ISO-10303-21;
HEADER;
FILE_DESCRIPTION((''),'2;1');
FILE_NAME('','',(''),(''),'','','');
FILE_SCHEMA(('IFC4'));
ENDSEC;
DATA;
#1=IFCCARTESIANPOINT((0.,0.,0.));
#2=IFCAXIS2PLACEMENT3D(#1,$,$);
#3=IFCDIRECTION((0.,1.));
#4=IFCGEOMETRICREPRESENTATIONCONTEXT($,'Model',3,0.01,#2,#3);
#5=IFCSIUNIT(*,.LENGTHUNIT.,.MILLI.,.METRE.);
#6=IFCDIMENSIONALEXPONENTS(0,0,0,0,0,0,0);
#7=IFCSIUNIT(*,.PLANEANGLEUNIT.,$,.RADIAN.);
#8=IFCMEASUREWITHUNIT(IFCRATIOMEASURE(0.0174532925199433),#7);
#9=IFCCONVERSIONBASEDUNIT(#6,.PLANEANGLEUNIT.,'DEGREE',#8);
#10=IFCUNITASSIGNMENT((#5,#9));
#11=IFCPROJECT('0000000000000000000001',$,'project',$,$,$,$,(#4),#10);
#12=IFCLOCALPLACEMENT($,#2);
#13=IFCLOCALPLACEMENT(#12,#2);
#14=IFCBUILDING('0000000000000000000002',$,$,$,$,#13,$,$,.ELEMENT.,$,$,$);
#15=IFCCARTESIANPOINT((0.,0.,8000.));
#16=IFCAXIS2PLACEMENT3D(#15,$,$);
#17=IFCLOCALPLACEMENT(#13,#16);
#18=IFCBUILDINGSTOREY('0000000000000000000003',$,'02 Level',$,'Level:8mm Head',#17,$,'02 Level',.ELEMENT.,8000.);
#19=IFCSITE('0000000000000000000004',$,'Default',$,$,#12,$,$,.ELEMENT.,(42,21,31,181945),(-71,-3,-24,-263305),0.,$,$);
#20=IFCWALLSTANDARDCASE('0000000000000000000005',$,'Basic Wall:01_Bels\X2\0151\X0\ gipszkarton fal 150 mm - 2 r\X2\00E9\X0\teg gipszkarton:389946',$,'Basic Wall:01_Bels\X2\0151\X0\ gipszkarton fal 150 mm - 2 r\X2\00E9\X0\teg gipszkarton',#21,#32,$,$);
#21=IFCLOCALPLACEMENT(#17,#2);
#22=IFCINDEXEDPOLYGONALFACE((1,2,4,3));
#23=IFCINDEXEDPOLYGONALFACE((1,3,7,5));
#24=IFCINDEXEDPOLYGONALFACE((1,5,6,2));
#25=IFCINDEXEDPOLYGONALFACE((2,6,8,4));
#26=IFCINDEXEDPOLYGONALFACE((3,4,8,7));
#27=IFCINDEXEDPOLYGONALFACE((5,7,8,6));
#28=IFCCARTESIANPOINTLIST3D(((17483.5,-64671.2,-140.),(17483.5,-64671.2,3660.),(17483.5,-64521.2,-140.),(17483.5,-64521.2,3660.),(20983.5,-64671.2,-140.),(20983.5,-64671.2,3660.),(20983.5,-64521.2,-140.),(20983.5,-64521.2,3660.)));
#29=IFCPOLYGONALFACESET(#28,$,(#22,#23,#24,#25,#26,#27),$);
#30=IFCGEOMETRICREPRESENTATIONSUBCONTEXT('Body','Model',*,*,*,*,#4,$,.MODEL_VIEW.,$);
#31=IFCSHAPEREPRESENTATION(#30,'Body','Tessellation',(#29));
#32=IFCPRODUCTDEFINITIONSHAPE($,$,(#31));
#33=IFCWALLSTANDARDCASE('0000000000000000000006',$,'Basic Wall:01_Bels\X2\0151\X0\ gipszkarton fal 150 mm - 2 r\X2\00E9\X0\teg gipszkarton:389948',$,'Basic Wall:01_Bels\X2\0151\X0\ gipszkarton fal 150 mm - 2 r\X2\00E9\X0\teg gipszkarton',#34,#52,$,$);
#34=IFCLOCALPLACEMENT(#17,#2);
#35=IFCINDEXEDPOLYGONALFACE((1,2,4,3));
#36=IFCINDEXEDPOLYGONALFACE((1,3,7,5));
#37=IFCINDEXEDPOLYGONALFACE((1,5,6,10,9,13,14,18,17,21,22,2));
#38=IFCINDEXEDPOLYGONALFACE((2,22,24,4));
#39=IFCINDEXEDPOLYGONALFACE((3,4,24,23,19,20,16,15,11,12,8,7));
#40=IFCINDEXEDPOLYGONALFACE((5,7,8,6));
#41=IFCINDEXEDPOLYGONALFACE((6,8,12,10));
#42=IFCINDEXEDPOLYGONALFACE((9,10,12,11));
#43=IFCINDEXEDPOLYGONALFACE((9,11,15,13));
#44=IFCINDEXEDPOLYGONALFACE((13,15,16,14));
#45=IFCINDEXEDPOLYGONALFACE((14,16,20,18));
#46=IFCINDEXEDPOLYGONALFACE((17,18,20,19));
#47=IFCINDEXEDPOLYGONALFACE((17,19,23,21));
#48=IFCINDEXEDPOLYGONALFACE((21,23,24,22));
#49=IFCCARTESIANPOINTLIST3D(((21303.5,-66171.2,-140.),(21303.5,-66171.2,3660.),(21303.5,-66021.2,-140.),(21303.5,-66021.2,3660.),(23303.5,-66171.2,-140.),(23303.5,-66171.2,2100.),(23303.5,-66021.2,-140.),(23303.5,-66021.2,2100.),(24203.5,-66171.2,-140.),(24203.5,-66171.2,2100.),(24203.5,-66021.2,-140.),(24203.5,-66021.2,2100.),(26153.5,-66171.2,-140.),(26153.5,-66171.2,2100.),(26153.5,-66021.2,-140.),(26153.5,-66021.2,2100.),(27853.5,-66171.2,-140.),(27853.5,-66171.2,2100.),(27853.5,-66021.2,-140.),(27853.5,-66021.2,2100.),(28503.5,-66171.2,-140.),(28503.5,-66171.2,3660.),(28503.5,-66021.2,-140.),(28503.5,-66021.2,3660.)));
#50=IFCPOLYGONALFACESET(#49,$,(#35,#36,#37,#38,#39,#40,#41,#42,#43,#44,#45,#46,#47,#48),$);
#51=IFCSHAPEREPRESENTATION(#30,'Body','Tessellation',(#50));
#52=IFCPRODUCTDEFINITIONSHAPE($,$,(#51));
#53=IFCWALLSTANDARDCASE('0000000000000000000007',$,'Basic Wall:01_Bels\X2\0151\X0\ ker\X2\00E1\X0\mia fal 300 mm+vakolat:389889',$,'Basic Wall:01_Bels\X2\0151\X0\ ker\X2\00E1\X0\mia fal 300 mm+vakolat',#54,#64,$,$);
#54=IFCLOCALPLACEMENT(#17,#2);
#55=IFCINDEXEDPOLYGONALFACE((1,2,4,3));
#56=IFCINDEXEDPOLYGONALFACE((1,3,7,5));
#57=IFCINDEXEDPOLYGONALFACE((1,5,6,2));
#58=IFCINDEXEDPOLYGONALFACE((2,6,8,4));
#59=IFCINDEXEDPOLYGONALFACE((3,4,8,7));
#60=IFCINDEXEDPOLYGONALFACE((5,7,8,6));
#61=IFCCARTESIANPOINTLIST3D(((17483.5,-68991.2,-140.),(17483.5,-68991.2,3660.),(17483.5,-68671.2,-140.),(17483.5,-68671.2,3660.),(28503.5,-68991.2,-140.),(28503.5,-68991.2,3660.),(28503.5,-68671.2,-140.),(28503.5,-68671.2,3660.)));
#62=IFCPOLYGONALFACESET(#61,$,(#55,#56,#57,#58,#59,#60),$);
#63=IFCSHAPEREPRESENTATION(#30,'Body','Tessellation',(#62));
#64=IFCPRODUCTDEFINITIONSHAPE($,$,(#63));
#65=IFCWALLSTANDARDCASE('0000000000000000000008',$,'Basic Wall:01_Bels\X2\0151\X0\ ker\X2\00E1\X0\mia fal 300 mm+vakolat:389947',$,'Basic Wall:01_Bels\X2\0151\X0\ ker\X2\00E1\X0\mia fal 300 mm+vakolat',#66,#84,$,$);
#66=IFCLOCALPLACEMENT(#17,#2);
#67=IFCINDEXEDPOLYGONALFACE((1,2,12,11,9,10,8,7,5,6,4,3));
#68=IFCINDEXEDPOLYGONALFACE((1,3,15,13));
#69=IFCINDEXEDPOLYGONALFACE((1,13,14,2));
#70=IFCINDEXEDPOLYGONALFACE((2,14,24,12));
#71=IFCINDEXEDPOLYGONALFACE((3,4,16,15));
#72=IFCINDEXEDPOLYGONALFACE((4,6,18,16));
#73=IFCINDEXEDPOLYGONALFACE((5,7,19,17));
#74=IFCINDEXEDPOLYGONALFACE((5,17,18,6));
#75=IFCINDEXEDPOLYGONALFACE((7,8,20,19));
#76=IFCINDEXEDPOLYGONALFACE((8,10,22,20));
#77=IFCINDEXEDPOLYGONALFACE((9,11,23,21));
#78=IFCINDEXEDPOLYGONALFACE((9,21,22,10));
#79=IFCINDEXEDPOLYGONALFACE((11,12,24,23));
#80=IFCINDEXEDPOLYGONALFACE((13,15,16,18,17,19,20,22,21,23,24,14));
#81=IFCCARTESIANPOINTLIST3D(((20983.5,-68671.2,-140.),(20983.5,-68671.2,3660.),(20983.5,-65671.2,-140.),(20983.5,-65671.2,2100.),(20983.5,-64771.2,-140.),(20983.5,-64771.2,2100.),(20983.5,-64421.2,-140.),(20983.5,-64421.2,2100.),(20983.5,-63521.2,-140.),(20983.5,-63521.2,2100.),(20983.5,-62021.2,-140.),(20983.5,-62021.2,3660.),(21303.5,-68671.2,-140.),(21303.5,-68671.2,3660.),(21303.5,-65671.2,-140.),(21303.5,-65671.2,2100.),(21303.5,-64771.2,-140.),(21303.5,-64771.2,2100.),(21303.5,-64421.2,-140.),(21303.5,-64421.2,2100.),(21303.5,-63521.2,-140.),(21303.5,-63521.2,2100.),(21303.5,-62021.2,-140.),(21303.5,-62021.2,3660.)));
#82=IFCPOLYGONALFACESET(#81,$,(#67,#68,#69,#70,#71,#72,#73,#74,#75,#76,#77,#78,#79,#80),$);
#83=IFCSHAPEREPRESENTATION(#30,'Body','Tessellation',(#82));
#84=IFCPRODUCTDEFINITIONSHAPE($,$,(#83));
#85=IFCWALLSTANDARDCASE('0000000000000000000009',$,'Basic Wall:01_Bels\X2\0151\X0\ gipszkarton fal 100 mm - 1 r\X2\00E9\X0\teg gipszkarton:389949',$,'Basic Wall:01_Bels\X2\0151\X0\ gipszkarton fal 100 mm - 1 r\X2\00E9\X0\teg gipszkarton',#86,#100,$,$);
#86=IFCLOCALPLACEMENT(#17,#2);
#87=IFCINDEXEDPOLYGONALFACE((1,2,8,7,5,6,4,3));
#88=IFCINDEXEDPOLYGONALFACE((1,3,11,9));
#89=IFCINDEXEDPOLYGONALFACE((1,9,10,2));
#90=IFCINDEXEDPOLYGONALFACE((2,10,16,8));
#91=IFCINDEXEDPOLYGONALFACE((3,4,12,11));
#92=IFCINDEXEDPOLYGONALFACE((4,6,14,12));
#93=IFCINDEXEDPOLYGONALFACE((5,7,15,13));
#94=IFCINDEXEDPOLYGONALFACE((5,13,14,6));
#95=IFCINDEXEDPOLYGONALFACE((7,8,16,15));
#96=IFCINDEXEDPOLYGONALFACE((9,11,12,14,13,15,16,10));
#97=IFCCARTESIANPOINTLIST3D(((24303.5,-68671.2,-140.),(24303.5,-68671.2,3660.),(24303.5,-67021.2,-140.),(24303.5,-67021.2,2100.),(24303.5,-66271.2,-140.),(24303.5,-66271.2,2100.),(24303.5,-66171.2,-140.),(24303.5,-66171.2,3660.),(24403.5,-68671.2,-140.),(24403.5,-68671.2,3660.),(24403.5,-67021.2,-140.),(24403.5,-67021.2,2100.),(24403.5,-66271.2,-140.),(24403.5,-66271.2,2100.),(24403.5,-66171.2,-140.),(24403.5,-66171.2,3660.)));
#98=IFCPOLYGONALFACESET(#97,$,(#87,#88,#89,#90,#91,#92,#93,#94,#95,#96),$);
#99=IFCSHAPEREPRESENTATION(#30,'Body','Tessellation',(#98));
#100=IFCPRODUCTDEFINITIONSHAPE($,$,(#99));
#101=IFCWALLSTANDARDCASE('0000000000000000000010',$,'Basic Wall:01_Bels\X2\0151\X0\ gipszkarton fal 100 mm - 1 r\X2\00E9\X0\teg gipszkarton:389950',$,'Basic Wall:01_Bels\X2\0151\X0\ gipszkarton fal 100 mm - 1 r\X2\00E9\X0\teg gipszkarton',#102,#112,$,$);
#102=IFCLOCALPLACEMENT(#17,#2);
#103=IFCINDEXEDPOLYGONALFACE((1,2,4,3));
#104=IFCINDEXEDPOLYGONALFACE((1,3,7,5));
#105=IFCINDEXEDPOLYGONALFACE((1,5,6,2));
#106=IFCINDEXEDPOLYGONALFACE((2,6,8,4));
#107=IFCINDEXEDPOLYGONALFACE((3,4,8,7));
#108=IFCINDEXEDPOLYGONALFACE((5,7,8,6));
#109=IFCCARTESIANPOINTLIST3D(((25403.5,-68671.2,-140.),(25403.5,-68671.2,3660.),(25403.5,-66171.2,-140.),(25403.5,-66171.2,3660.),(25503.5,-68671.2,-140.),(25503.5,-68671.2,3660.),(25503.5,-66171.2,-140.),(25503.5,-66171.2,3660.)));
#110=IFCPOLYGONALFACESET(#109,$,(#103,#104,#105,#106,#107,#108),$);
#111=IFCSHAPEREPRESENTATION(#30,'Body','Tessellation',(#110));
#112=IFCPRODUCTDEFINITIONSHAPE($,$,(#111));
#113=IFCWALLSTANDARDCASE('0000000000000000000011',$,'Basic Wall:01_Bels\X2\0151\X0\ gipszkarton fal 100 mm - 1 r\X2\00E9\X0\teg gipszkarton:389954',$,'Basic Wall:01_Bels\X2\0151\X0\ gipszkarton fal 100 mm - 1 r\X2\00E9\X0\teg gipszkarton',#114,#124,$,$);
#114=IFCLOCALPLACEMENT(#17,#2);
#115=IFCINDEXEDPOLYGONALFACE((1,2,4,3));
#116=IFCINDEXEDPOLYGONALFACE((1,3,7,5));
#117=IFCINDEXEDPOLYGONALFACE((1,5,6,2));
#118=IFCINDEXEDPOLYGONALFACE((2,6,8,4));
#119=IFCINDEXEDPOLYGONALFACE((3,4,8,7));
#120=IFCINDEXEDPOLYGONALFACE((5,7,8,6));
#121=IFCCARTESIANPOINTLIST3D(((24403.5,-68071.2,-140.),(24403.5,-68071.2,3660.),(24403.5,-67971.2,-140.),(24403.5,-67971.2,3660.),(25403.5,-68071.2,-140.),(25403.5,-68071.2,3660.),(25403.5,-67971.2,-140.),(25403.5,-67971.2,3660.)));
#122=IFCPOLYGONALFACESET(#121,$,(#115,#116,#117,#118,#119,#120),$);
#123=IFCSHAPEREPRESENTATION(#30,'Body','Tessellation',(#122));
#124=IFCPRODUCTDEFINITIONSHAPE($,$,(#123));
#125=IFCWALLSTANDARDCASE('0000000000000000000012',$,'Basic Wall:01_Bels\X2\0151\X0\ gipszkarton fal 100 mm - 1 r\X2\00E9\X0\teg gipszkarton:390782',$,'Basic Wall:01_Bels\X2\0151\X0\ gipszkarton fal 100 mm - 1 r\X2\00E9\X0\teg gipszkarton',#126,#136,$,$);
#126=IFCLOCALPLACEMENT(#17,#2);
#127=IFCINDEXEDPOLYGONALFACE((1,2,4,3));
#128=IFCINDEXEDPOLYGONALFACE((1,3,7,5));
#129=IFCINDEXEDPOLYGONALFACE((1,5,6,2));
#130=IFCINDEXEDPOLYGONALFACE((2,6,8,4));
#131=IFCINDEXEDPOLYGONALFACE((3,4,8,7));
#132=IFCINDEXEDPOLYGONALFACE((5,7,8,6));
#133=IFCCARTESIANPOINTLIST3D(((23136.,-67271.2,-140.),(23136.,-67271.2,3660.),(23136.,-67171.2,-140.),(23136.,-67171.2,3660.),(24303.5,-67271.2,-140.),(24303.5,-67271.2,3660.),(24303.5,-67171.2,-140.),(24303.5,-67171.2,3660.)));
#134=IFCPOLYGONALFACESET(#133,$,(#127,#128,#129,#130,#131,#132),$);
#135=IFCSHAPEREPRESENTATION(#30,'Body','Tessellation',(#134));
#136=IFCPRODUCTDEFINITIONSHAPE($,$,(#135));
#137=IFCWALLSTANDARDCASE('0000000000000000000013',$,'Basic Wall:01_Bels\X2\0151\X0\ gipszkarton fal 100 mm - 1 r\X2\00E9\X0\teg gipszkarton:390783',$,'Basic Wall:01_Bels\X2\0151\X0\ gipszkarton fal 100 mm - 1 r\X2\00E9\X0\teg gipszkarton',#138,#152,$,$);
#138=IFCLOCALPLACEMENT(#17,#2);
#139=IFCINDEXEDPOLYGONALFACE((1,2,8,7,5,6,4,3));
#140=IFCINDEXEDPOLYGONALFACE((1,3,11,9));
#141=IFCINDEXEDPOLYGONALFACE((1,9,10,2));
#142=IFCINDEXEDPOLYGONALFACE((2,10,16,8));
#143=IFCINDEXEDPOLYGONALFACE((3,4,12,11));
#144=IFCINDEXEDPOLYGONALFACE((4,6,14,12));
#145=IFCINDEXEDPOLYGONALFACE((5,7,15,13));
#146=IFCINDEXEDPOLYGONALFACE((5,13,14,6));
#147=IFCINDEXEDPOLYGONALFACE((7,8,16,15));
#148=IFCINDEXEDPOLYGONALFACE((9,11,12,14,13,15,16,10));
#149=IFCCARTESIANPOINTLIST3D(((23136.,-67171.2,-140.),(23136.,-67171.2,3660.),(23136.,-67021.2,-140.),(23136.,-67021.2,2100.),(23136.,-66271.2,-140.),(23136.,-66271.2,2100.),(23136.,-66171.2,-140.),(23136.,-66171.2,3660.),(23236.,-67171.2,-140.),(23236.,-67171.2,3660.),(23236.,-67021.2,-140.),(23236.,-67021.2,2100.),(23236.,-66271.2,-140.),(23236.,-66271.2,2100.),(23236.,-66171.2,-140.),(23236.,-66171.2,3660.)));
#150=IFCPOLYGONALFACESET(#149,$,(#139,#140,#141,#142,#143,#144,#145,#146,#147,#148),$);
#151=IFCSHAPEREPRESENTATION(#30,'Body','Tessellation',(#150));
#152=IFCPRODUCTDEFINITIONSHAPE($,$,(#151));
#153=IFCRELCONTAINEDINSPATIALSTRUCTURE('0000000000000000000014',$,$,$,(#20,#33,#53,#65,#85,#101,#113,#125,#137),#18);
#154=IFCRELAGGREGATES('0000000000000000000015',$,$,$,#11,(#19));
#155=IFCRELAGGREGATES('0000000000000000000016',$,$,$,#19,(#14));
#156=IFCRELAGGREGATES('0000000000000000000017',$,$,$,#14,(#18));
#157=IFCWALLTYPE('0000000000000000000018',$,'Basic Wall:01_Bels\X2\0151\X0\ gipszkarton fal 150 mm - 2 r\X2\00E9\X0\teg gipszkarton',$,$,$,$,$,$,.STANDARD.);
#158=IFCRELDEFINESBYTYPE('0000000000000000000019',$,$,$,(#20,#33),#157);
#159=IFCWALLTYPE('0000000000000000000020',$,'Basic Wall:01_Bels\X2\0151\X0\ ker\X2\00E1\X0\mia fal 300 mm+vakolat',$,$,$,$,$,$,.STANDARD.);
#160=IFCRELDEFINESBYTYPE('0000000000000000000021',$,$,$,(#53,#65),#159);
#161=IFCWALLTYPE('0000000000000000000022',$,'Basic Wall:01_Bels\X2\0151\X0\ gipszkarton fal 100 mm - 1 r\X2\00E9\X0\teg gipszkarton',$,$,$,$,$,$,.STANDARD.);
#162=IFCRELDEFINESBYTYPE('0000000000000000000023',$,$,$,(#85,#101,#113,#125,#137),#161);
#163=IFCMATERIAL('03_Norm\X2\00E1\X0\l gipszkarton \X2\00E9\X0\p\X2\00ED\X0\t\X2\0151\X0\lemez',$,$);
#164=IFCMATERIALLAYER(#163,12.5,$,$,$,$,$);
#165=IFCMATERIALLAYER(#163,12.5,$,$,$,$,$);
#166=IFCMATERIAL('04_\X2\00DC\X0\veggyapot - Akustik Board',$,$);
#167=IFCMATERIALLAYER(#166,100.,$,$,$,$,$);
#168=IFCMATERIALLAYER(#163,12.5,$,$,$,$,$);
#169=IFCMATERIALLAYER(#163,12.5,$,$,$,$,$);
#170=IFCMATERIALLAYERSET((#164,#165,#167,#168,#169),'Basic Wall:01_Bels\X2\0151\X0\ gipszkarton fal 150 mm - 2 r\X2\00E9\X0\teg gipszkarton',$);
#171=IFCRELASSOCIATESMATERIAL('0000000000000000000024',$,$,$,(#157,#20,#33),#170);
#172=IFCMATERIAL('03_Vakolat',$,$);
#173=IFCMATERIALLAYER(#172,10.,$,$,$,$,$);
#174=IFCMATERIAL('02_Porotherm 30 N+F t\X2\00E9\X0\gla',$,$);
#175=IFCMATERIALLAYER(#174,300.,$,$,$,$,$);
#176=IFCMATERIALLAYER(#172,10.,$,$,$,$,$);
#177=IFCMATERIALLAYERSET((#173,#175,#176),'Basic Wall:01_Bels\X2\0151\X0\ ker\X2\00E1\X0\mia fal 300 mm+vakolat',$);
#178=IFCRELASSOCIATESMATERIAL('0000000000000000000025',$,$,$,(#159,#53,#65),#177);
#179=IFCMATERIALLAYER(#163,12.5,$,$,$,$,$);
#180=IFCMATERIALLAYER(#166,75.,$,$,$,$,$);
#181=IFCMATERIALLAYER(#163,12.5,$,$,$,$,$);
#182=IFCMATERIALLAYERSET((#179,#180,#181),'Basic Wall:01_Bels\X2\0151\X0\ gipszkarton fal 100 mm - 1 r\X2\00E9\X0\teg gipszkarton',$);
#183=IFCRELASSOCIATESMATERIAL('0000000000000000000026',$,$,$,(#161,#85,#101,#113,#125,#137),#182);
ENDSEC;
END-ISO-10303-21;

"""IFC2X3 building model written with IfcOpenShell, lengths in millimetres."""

from ifc_helpers import new_model, entity, si_unit, converted_unit, direction, frame, frame_2d, origin, place, context, subcontext, project, spatial, rectangle, extrude, material, layer, layer_set, layer_usage, type_object, element, save


model = new_model("IFC2X3")

# Units and contexts
model_context = context("Model", 3, precision=0.01, world=origin(), true_north=direction((0.0, 1.0)))
body_context = subcontext(model_context, "Body", "Model", "MODEL_VIEW")
ifc_project = project(units=[si_unit("LENGTHUNIT", "METRE", prefix="MILLI"), converted_unit("PLANEANGLEUNIT", "DEGREE", entity("IfcRatioMeasure", 0.0174532925199433), si_unit("PLANEANGLEUNIT", "RADIAN"), dimensions=[0, 0, 0, 0, 0, 0, 0])], contexts=[model_context])

# Site, building, storey
site_placement = place(None, origin())
site = spatial("IfcSite", under=ifc_project, at=site_placement, Name="Default", CompositionType="ELEMENT", RefLatitude=(42, 21, 31, 181945), RefLongitude=(-71, -3, -24, -263305), RefElevation=0.0)
building_placement = place(site_placement, origin())
building = spatial("IfcBuilding", under=site, at=building_placement, CompositionType="ELEMENT")
storey_placement = place(building_placement, frame((0.0, 0.0, 8000.0)))
storey = spatial("IfcBuildingStorey", under=building, at=storey_placement, Name="02 Level", ObjectType="Level:8mm Head", LongName="02 Level", CompositionType="ELEMENT", Elevation=8000.0)

# Wall
ifc_material_1 = material(Name="03_Normál gipszkarton építőlemez")
ifc_layer_1 = layer(ifc_material_1, 12.5)
ifc_layer_2 = layer(ifc_material_1, 12.5)
ifc_material_2 = material(Name="04_Üveggyapot - Akustik Board")
ifc_layer_3 = layer(ifc_material_2, 100.0)
ifc_layer_4 = layer(ifc_material_1, 12.5)
ifc_layer_5 = layer(ifc_material_1, 12.5)
ifc_layer_set_1 = layer_set([ifc_layer_1, ifc_layer_2, ifc_layer_3, ifc_layer_4, ifc_layer_5], Name="Basic Wall:01_Belső gipszkarton fal 150 mm - 2 réteg gipszkarton")
ifc_layer_usage_1 = layer_usage(ifc_layer_set_1, "AXIS2", "POSITIVE", -75.0)
wall_type_1 = type_object("IfcWallType", Name="Basic Wall:01_Belső gipszkarton fal 150 mm - 2 réteg gipszkarton", PredefinedType="STANDARD", material=ifc_layer_set_1)
wall_1_placement = place(storey_placement, frame((17483.5, -64596.2, -140.0)))
element("IfcWallStandardCase", 1, at=wall_1_placement, inside=storey, type_object=wall_type_1, material=ifc_layer_usage_1, Name="Basic Wall:01_Belső gipszkarton fal 150 mm - 2 réteg gipszkarton:389946", ObjectType="Basic Wall:01_Belső gipszkarton fal 150 mm - 2 réteg gipszkarton", context=body_context, shape_type="SweptSolid", body=[
    extrude(rectangle(XDim=3500.0, YDim=150.0, at=frame_2d((1750.0, 0.0), x_axis=(-1.0, 0.0))), origin(), (0.0, 0.0, 1.0), 3800.0),
])

# Wall, openings
ifc_layer_usage_2 = layer_usage(ifc_layer_set_1, "AXIS2", "POSITIVE", -75.0)
wall_2_placement = place(storey_placement, frame((21303.5, -66096.2, -140.0)))
wall_2 = element("IfcWallStandardCase", 2, at=wall_2_placement, inside=storey, type_object=wall_type_1, material=ifc_layer_usage_2, Name="Basic Wall:01_Belső gipszkarton fal 150 mm - 2 réteg gipszkarton:389948", ObjectType="Basic Wall:01_Belső gipszkarton fal 150 mm - 2 réteg gipszkarton", context=body_context, shape_type="SweptSolid", body=[
    extrude(rectangle(XDim=7200.0, YDim=150.0, at=frame_2d((3600.0, 0.0), x_axis=(-1.0, 0.0))), origin(), (0.0, 0.0, 1.0), 3800.0),
])
opening_1_placement = place(wall_2_placement, frame((4850.0, -75.0, 0.0)))
element("IfcOpeningElement", 3, at=opening_1_placement, cuts=wall_2, ObjectType="Opening", context=body_context, shape_type="SweptSolid", body=[
    extrude(rectangle(XDim=2240.0, YDim=1700.0, at=frame_2d((0.0, 0.0), x_axis=(1.0, 0.0))), frame((850.0, 0.0, 1120.0), z_axis=(0.0, 1.0, 0.0), x_axis=(0.0, 0.0, -1.0)), (0.0, 0.0, 1.0), 150.0),
])
opening_2_placement = place(wall_2_placement, frame((2000.0, -1599.0, 0.0)))
element("IfcOpeningElement", 4, at=opening_2_placement, cuts=wall_2, ObjectType="Opening", context=body_context, shape_type="SweptSolid", body=[
    extrude(rectangle(XDim=2240.0, YDim=900.0, at=frame_2d((0.0, 0.0), x_axis=(0.0, 1.0))), frame((450.0, 0.0, 1120.0), z_axis=(0.0, 1.0, 0.0), x_axis=(-1.0, 0.0, 0.0)), (0.0, 0.0, 1.0), 3048.0),
])

# Wall
ifc_material_3 = material(Name="03_Vakolat")
ifc_layer_6 = layer(ifc_material_3, 10.0)
ifc_material_4 = material(Name="02_Porotherm 30 N+F tégla")
ifc_layer_7 = layer(ifc_material_4, 300.0)
ifc_layer_8 = layer(ifc_material_3, 10.0)
ifc_layer_set_2 = layer_set([ifc_layer_6, ifc_layer_7, ifc_layer_8], Name="Basic Wall:01_Belső kerámia fal 300 mm+vakolat")
ifc_layer_usage_3 = layer_usage(ifc_layer_set_2, "AXIS2", "NEGATIVE", 160.0)
wall_type_2 = type_object("IfcWallType", Name="Basic Wall:01_Belső kerámia fal 300 mm+vakolat", PredefinedType="STANDARD", material=ifc_layer_set_2)
wall_3_placement = place(storey_placement, frame((17483.5, -68831.2, -140.0)))
element("IfcWallStandardCase", 5, at=wall_3_placement, inside=storey, type_object=wall_type_2, material=ifc_layer_usage_3, Name="Basic Wall:01_Belső kerámia fal 300 mm+vakolat:389889", ObjectType="Basic Wall:01_Belső kerámia fal 300 mm+vakolat", context=body_context, shape_type="SweptSolid", body=[
    extrude(rectangle(XDim=11020.0, YDim=320.0, at=frame_2d((5510.0, 0.0), x_axis=(-1.0, 0.0))), origin(), (0.0, 0.0, 1.0), 3800.0),
])

# Wall, openings
ifc_layer_usage_4 = layer_usage(ifc_layer_set_2, "AXIS2", "POSITIVE", -160.0)
wall_4_placement = place(storey_placement, frame((21143.5, -68671.2, -140.0), z_axis=(0.0, 0.0, 1.0), x_axis=(0.0, 1.0, 0.0)))
wall_4 = element("IfcWallStandardCase", 6, at=wall_4_placement, inside=storey, type_object=wall_type_2, material=ifc_layer_usage_4, Name="Basic Wall:01_Belső kerámia fal 300 mm+vakolat:389947", ObjectType="Basic Wall:01_Belső kerámia fal 300 mm+vakolat", context=body_context, shape_type="SweptSolid", body=[
    extrude(rectangle(XDim=6650.0, YDim=320.0, at=frame_2d((3325.0, 0.0), x_axis=(-1.0, 0.0))), origin(), (0.0, 0.0, 1.0), 3800.0),
])
opening_3_placement = place(wall_4_placement, frame((3000.0, 1364.0, 0.0), z_axis=(0.0, 0.0, 1.0), x_axis=(0.0, -1.0, 0.0)))
element("IfcOpeningElement", 7, at=opening_3_placement, cuts=wall_4, ObjectType="Opening", context=body_context, shape_type="SweptSolid", body=[
    extrude(rectangle(XDim=2240.0, YDim=900.0, at=frame_2d((0.0, 0.0), x_axis=(1.0, 0.0))), frame((3048.0, 450.0, 1120.0), z_axis=(-1.0, 0.0, 0.0), x_axis=(0.0, 0.0, 1.0)), (0.0, 0.0, 1.0), 3048.0),
])
opening_4_placement = place(wall_4_placement, frame((4250.0, 1364.0, 0.0), z_axis=(0.0, 0.0, 1.0), x_axis=(0.0, -1.0, 0.0)))
element("IfcOpeningElement", 8, at=opening_4_placement, cuts=wall_4, ObjectType="Opening", context=body_context, shape_type="SweptSolid", body=[
    extrude(rectangle(XDim=2240.0, YDim=900.0, at=frame_2d((0.0, 0.0), x_axis=(0.0, 1.0))), frame((3048.0, 450.0, 1120.0), z_axis=(-1.0, 0.0, 0.0), x_axis=(0.0, -1.0, 0.0)), (0.0, 0.0, 1.0), 3048.0),
])

# Wall, opening
ifc_layer_9 = layer(ifc_material_1, 12.5)
ifc_layer_10 = layer(ifc_material_2, 75.0)
ifc_layer_11 = layer(ifc_material_1, 12.5)
ifc_layer_set_3 = layer_set([ifc_layer_9, ifc_layer_10, ifc_layer_11], Name="Basic Wall:01_Belső gipszkarton fal 100 mm - 1 réteg gipszkarton")
ifc_layer_usage_5 = layer_usage(ifc_layer_set_3, "AXIS2", "POSITIVE", -50.0)
wall_type_3 = type_object("IfcWallType", Name="Basic Wall:01_Belső gipszkarton fal 100 mm - 1 réteg gipszkarton", PredefinedType="STANDARD", material=ifc_layer_set_3)
wall_5_placement = place(storey_placement, frame((24353.5, -66171.2, -140.0), z_axis=(0.0, 0.0, 1.0), x_axis=(0.0, -1.0, 0.0)))
wall_5 = element("IfcWallStandardCase", 9, at=wall_5_placement, inside=storey, type_object=wall_type_3, material=ifc_layer_usage_5, Name="Basic Wall:01_Belső gipszkarton fal 100 mm - 1 réteg gipszkarton:389949", ObjectType="Basic Wall:01_Belső gipszkarton fal 100 mm - 1 réteg gipszkarton", context=body_context, shape_type="SweptSolid", body=[
    extrude(rectangle(XDim=2500.0, YDim=100.0, at=frame_2d((1250.0, 0.0), x_axis=(-1.0, 0.0))), origin(), (0.0, 0.0, 1.0), 3800.0),
])
opening_5_placement = place(wall_5_placement, frame((850.0, -1574.0, 0.0), z_axis=(0.0, 0.0, 1.0), x_axis=(0.0, 1.0, 0.0)))
element("IfcOpeningElement", 10, at=opening_5_placement, cuts=wall_5, ObjectType="Opening", context=body_context, shape_type="SweptSolid", body=[
    extrude(rectangle(XDim=2240.0, YDim=750.0, at=frame_2d((0.0, 0.0), x_axis=(0.0, 1.0))), frame((0.0, 375.0, 1120.0), z_axis=(1.0, 0.0, 0.0), x_axis=(0.0, 1.0, 0.0)), (0.0, 0.0, 1.0), 3048.0),
])

# Walls
ifc_layer_usage_6 = layer_usage(ifc_layer_set_3, "AXIS2", "POSITIVE", -50.0)
wall_6_placement = place(storey_placement, frame((25453.5, -66171.2, -140.0), z_axis=(0.0, 0.0, 1.0), x_axis=(0.0, -1.0, 0.0)))
element("IfcWallStandardCase", 11, at=wall_6_placement, inside=storey, type_object=wall_type_3, material=ifc_layer_usage_6, Name="Basic Wall:01_Belső gipszkarton fal 100 mm - 1 réteg gipszkarton:389950", ObjectType="Basic Wall:01_Belső gipszkarton fal 100 mm - 1 réteg gipszkarton", context=body_context, shape_type="SweptSolid", body=[
    extrude(rectangle(XDim=2500.0, YDim=100.0, at=frame_2d((1250.0, 0.0), x_axis=(-1.0, 0.0))), origin(), (0.0, 0.0, 1.0), 3800.0),
])
ifc_layer_usage_7 = layer_usage(ifc_layer_set_3, "AXIS2", "POSITIVE", -50.0)
wall_7_placement = place(storey_placement, frame((24403.5, -68021.2, -140.0)))
element("IfcWallStandardCase", 12, at=wall_7_placement, inside=storey, type_object=wall_type_3, material=ifc_layer_usage_7, Name="Basic Wall:01_Belső gipszkarton fal 100 mm - 1 réteg gipszkarton:389954", ObjectType="Basic Wall:01_Belső gipszkarton fal 100 mm - 1 réteg gipszkarton", context=body_context, shape_type="SweptSolid", body=[
    extrude(rectangle(XDim=1000.0, YDim=100.0, at=frame_2d((500.0, 0.0), x_axis=(-1.0, 0.0))), origin(), (0.0, 0.0, 1.0), 3800.0),
])
ifc_layer_usage_8 = layer_usage(ifc_layer_set_3, "AXIS2", "POSITIVE", -50.0)
wall_8_placement = place(storey_placement, frame((24303.5, -67221.2, -140.0), z_axis=(0.0, 0.0, 1.0), x_axis=(-1.0, 0.0, 0.0)))
element("IfcWallStandardCase", 13, at=wall_8_placement, inside=storey, type_object=wall_type_3, material=ifc_layer_usage_8, Name="Basic Wall:01_Belső gipszkarton fal 100 mm - 1 réteg gipszkarton:390782", ObjectType="Basic Wall:01_Belső gipszkarton fal 100 mm - 1 réteg gipszkarton", context=body_context, shape_type="SweptSolid", body=[
    extrude(rectangle(XDim=1167.5, YDim=100.0, at=frame_2d((583.8, 0.0), x_axis=(-1.0, 0.0))), origin(), (0.0, 0.0, 1.0), 3800.0),
])

# Wall, opening
ifc_layer_usage_9 = layer_usage(ifc_layer_set_3, "AXIS2", "POSITIVE", -50.0)
wall_9_placement = place(storey_placement, frame((23186.0, -67171.2, -140.0), z_axis=(0.0, 0.0, 1.0), x_axis=(0.0, 1.0, 0.0)))
wall_9 = element("IfcWallStandardCase", 14, at=wall_9_placement, inside=storey, type_object=wall_type_3, material=ifc_layer_usage_9, Name="Basic Wall:01_Belső gipszkarton fal 100 mm - 1 réteg gipszkarton:390783", ObjectType="Basic Wall:01_Belső gipszkarton fal 100 mm - 1 réteg gipszkarton", context=body_context, shape_type="SweptSolid", body=[
    extrude(rectangle(XDim=1000.0, YDim=100.0, at=frame_2d((500.0, 0.0), x_axis=(-1.0, 0.0))), origin(), (0.0, 0.0, 1.0), 3800.0),
])
opening_6_placement = place(wall_9_placement, frame((150.0, 1474.0, 0.0), z_axis=(0.0, 0.0, 1.0), x_axis=(0.0, -1.0, 0.0)))
element("IfcOpeningElement", 15, at=opening_6_placement, cuts=wall_9, ObjectType="Opening", context=body_context, shape_type="SweptSolid", body=[
    extrude(rectangle(XDim=2240.0, YDim=750.0, at=frame_2d((0.0, 0.0), x_axis=(1.0, 0.0))), frame((3048.0, 375.0, 1120.0), z_axis=(-1.0, 0.0, 0.0), x_axis=(0.0, 0.0, 1.0)), (0.0, 0.0, 1.0), 3048.0),
])

save(model, "model.ifc")
